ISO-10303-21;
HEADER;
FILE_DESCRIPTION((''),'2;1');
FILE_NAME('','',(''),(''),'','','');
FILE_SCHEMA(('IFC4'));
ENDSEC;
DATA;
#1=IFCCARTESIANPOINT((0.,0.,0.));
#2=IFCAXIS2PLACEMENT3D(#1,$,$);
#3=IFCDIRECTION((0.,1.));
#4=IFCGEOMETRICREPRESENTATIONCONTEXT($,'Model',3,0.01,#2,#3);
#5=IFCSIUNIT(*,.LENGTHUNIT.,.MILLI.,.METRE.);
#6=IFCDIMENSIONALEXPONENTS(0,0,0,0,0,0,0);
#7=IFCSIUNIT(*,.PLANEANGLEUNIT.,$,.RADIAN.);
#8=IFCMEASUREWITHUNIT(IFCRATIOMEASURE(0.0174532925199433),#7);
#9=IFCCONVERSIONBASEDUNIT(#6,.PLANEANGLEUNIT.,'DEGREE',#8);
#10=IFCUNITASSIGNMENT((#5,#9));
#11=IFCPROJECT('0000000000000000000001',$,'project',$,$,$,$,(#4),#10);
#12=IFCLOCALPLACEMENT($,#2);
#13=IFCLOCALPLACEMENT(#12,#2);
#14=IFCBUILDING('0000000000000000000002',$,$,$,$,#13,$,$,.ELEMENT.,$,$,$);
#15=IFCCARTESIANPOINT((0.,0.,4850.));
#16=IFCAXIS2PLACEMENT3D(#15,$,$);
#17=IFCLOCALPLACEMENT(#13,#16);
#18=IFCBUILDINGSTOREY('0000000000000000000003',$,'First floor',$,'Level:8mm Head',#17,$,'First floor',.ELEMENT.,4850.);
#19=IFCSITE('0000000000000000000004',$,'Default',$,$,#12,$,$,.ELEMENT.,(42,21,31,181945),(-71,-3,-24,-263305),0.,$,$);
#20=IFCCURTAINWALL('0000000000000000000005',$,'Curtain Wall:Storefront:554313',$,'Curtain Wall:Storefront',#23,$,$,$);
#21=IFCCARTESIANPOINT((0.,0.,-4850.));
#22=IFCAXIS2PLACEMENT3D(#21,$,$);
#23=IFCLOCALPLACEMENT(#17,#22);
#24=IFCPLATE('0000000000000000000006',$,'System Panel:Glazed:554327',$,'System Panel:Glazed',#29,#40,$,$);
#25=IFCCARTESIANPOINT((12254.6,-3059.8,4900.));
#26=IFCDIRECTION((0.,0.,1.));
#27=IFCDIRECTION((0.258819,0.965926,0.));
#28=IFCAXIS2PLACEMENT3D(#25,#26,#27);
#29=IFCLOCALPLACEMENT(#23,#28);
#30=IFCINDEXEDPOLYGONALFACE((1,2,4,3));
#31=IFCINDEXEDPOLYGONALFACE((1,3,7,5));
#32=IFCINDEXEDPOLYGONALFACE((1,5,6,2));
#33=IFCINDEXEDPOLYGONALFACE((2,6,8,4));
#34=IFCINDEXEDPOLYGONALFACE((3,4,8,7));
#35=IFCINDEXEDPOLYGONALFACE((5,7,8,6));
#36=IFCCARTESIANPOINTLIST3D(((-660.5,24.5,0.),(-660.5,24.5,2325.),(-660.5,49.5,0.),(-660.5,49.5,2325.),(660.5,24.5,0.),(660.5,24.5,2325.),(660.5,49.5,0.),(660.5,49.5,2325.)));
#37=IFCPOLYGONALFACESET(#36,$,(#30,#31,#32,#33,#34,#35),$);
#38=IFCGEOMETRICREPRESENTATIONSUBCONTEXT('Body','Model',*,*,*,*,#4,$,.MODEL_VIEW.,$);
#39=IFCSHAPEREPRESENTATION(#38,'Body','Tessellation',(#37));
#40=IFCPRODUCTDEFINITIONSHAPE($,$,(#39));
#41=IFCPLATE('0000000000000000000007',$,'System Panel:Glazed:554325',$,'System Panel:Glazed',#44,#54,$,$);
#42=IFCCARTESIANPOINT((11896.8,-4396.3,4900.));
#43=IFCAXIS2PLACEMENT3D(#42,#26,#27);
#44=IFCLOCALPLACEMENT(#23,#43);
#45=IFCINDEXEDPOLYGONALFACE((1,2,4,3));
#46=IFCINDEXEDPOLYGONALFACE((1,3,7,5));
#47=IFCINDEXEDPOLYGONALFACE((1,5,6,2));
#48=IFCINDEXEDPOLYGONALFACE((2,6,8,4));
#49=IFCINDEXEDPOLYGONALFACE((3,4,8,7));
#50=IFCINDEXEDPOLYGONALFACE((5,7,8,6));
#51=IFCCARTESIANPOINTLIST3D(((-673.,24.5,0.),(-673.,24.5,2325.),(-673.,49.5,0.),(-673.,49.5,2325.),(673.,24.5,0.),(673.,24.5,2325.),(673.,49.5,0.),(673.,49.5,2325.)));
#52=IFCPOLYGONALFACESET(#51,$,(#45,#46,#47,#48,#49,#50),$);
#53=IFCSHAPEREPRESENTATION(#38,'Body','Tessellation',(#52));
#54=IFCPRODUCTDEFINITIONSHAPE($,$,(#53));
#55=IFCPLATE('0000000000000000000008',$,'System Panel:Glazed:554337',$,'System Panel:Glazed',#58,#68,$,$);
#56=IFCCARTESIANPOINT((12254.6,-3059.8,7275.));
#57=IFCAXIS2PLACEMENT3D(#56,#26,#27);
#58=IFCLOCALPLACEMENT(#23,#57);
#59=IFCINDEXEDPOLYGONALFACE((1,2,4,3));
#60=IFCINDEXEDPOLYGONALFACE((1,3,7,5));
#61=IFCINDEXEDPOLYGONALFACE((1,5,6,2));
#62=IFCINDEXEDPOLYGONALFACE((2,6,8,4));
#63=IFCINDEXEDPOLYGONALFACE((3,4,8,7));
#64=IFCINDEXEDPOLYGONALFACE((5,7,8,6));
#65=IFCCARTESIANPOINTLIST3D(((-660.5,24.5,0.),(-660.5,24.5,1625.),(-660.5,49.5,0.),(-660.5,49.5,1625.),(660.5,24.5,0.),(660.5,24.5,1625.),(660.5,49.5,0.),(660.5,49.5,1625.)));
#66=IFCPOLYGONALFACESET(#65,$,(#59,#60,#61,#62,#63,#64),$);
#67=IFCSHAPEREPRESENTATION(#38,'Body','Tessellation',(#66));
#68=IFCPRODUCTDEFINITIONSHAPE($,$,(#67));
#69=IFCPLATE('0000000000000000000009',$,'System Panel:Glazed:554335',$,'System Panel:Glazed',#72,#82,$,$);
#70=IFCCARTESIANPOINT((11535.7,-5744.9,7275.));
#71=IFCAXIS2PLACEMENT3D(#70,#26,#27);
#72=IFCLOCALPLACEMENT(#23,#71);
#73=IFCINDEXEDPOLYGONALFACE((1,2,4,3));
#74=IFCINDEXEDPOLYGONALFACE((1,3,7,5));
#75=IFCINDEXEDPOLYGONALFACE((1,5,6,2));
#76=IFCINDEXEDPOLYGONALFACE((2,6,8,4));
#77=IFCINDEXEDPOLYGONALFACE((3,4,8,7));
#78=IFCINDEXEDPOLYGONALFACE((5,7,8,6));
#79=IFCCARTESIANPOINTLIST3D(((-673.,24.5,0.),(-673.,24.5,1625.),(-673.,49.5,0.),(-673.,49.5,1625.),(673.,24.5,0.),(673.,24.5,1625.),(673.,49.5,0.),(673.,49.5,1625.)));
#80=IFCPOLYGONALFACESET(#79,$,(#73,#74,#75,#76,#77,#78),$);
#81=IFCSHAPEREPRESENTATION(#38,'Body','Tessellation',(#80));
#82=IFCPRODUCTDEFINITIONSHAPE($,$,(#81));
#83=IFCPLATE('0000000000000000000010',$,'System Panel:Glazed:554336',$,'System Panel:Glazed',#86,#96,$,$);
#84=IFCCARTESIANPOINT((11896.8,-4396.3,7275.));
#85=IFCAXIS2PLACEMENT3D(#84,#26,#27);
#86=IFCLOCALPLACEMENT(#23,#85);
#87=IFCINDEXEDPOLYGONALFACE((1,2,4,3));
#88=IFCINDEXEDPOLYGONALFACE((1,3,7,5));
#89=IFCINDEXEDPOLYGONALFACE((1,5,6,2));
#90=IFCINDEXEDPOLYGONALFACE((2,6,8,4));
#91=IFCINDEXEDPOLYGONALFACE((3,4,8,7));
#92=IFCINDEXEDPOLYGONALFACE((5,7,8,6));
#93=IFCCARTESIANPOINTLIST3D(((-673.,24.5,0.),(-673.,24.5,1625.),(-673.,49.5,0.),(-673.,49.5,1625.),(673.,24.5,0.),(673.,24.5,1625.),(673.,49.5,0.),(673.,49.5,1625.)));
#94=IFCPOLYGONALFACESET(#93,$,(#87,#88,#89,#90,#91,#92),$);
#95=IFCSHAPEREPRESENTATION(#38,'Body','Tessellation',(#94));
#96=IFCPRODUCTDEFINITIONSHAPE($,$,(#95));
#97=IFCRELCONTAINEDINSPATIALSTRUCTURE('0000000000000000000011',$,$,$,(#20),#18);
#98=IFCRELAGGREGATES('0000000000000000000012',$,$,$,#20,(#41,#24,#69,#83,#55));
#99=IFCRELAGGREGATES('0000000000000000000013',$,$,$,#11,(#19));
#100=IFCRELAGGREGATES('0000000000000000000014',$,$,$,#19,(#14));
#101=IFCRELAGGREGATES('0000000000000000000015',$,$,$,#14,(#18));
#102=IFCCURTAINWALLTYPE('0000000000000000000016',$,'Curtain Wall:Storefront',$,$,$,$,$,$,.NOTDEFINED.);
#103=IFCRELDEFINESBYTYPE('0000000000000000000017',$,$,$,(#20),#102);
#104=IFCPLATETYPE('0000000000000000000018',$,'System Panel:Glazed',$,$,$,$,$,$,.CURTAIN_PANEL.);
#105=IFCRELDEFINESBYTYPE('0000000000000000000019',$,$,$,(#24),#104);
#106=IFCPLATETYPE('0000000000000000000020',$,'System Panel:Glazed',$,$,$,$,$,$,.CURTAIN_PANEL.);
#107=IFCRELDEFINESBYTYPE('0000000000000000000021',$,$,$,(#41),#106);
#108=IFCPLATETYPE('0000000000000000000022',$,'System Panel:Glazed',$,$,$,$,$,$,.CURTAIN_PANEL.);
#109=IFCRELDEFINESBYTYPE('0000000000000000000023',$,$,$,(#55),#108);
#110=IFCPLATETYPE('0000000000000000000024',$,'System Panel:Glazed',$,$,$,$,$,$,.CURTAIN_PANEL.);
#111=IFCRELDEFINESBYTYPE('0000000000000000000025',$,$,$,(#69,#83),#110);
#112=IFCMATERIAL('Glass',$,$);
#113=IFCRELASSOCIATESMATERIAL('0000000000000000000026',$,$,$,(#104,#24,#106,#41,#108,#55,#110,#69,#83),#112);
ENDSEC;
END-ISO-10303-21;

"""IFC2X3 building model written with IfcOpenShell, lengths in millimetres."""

from ifc_helpers import new_model, entity, si_unit, converted_unit, direction, frame, frame_2d, origin, place, context, subcontext, project, spatial, rectangle, extrude, source, transform, mapped, material, type_object, type_shapes, element, aggregate, save


model = new_model("IFC2X3")

# Units and contexts
model_context = context("Model", 3, precision=0.01, world=origin(), true_north=direction((0.0, 1.0)))
body_context = subcontext(model_context, "Body", "Model", "MODEL_VIEW")
ifc_project = project(units=[si_unit("LENGTHUNIT", "METRE", prefix="MILLI"), converted_unit("PLANEANGLEUNIT", "DEGREE", entity("IfcRatioMeasure", 0.0174532925199433), si_unit("PLANEANGLEUNIT", "RADIAN"), dimensions=[0, 0, 0, 0, 0, 0, 0])], contexts=[model_context])

# Site, building, storey
site_placement = place(None, origin())
site = spatial("IfcSite", under=ifc_project, at=site_placement, Name="Default", CompositionType="ELEMENT", RefLatitude=(42, 21, 31, 181945), RefLongitude=(-71, -3, -24, -263305), RefElevation=0.0)
building_placement = place(site_placement, origin())
building = spatial("IfcBuilding", under=site, at=building_placement, CompositionType="ELEMENT")
storey_placement = place(building_placement, frame((0.0, 0.0, 4850.0)))
storey = spatial("IfcBuildingStorey", under=building, at=storey_placement, Name="First floor", ObjectType="Level:8mm Head", LongName="First floor", CompositionType="ELEMENT", Elevation=4850.0)

# Shared definitions
curtain_wall_type = type_object("IfcCurtainWallType", Name="Curtain Wall:Storefront", PredefinedType="NOTDEFINED")

# Curtain wall
curtain_wall_1_placement = place(storey_placement, frame((0.0, 0.0, -4850.0)))
curtain_wall_1 = element("IfcCurtainWall", 1, at=curtain_wall_1_placement, inside=storey, type_object=curtain_wall_type, Name="Curtain Wall:Storefront:554313", ObjectType="Curtain Wall:Storefront")

# Plates
ifc_material_1 = material(Name="Glass")
plate_type_1 = type_object("IfcPlateType", Name="System Panel:Glazed", PredefinedType="CURTAIN_PANEL", material=ifc_material_1)
shared_shape_1 = source(origin(), body_context, "Body", "SweptSolid", [
    extrude(rectangle(XDim=25.0, YDim=1321.1, at=frame_2d((0.0, 0.0), x_axis=(1.0, 0.0))), frame((0.0, 37.0, 0.0), z_axis=(0.0, 0.0, 1.0), x_axis=(0.0, 1.0, 0.0)), (0.0, 0.0, 1.0), 2325.0),
])
type_shapes(plate_type_1, [shared_shape_1])
plate_1_placement = place(curtain_wall_1_placement, frame((12254.6, -3059.8, 4900.0), z_axis=(0.0, 0.0, 1.0), x_axis=(0.258819, 0.965926, 0.0)))
plate_1 = element("IfcPlate", 2, at=plate_1_placement, type_object=plate_type_1, material=ifc_material_1, Name="System Panel:Glazed:554327", ObjectType="System Panel:Glazed", context=body_context, shape_type="MappedRepresentation", body=[
    mapped(shared_shape_1, transform((0.0, 0.0, 0.0), scale=1.0)),
])
plate_type_2 = type_object("IfcPlateType", Name="System Panel:Glazed", PredefinedType="CURTAIN_PANEL", material=ifc_material_1)
shared_shape_2 = source(origin(), body_context, "Body", "SweptSolid", [
    extrude(rectangle(XDim=25.0, YDim=1346.1, at=frame_2d((0.0, 0.0), x_axis=(1.0, 0.0))), frame((0.0, 37.0, 0.0), z_axis=(0.0, 0.0, 1.0), x_axis=(0.0, 1.0, 0.0)), (0.0, 0.0, 1.0), 2325.0),
])
type_shapes(plate_type_2, [shared_shape_2])
plate_2_placement = place(curtain_wall_1_placement, frame((11896.8, -4396.3, 4900.0), z_axis=(0.0, 0.0, 1.0), x_axis=(0.258819, 0.965926, 0.0)))
plate_2 = element("IfcPlate", 3, at=plate_2_placement, type_object=plate_type_2, material=ifc_material_1, Name="System Panel:Glazed:554325", ObjectType="System Panel:Glazed", context=body_context, shape_type="MappedRepresentation", body=[
    mapped(shared_shape_2, transform((0.0, 0.0, 0.0), scale=1.0)),
])
plate_type_3 = type_object("IfcPlateType", Name="System Panel:Glazed", PredefinedType="CURTAIN_PANEL", material=ifc_material_1)
shared_shape_3 = source(origin(), body_context, "Body", "SweptSolid", [
    extrude(rectangle(XDim=25.0, YDim=1321.1, at=frame_2d((0.0, 0.0), x_axis=(1.0, 0.0))), frame((0.0, 37.0, 0.0), z_axis=(0.0, 0.0, 1.0), x_axis=(0.0, 1.0, 0.0)), (0.0, 0.0, 1.0), 1625.0),
])
type_shapes(plate_type_3, [shared_shape_3])
plate_3_placement = place(curtain_wall_1_placement, frame((12254.6, -3059.8, 7275.0), z_axis=(0.0, 0.0, 1.0), x_axis=(0.258819, 0.965926, 0.0)))
plate_3 = element("IfcPlate", 4, at=plate_3_placement, type_object=plate_type_3, material=ifc_material_1, Name="System Panel:Glazed:554337", ObjectType="System Panel:Glazed", context=body_context, shape_type="MappedRepresentation", body=[
    mapped(shared_shape_3, transform((0.0, 0.0, 0.0), scale=1.0)),
])
plate_type_4 = type_object("IfcPlateType", Name="System Panel:Glazed", PredefinedType="CURTAIN_PANEL", material=ifc_material_1)
shared_shape_4 = source(origin(), body_context, "Body", "SweptSolid", [
    extrude(rectangle(XDim=25.0, YDim=1346.1, at=frame_2d((0.0, 0.0), x_axis=(1.0, 0.0))), frame((0.0, 37.0, 0.0), z_axis=(0.0, 0.0, 1.0), x_axis=(0.0, 1.0, 0.0)), (0.0, 0.0, 1.0), 1625.0),
])
type_shapes(plate_type_4, [shared_shape_4])
plate_4_placement = place(curtain_wall_1_placement, frame((11535.7, -5744.9, 7275.0), z_axis=(0.0, 0.0, 1.0), x_axis=(0.258819, 0.965926, 0.0)))
plate_4 = element("IfcPlate", 5, at=plate_4_placement, type_object=plate_type_4, material=ifc_material_1, Name="System Panel:Glazed:554335", ObjectType="System Panel:Glazed", context=body_context, shape_type="MappedRepresentation", body=[
    mapped(shared_shape_4, transform((0.0, 0.0, 0.0), scale=1.0)),
])
plate_5_placement = place(curtain_wall_1_placement, frame((11896.8, -4396.3, 7275.0), z_axis=(0.0, 0.0, 1.0), x_axis=(0.258819, 0.965926, 0.0)))
plate_5 = element("IfcPlate", 6, at=plate_5_placement, type_object=plate_type_4, material=ifc_material_1, Name="System Panel:Glazed:554336", ObjectType="System Panel:Glazed", context=body_context, shape_type="MappedRepresentation", body=[
    mapped(shared_shape_4, transform((0.0, 0.0, 0.0), scale=1.0)),
])
aggregate(curtain_wall_1, [plate_2, plate_1, plate_4, plate_5, plate_3])

save(model, "model.ifc")
